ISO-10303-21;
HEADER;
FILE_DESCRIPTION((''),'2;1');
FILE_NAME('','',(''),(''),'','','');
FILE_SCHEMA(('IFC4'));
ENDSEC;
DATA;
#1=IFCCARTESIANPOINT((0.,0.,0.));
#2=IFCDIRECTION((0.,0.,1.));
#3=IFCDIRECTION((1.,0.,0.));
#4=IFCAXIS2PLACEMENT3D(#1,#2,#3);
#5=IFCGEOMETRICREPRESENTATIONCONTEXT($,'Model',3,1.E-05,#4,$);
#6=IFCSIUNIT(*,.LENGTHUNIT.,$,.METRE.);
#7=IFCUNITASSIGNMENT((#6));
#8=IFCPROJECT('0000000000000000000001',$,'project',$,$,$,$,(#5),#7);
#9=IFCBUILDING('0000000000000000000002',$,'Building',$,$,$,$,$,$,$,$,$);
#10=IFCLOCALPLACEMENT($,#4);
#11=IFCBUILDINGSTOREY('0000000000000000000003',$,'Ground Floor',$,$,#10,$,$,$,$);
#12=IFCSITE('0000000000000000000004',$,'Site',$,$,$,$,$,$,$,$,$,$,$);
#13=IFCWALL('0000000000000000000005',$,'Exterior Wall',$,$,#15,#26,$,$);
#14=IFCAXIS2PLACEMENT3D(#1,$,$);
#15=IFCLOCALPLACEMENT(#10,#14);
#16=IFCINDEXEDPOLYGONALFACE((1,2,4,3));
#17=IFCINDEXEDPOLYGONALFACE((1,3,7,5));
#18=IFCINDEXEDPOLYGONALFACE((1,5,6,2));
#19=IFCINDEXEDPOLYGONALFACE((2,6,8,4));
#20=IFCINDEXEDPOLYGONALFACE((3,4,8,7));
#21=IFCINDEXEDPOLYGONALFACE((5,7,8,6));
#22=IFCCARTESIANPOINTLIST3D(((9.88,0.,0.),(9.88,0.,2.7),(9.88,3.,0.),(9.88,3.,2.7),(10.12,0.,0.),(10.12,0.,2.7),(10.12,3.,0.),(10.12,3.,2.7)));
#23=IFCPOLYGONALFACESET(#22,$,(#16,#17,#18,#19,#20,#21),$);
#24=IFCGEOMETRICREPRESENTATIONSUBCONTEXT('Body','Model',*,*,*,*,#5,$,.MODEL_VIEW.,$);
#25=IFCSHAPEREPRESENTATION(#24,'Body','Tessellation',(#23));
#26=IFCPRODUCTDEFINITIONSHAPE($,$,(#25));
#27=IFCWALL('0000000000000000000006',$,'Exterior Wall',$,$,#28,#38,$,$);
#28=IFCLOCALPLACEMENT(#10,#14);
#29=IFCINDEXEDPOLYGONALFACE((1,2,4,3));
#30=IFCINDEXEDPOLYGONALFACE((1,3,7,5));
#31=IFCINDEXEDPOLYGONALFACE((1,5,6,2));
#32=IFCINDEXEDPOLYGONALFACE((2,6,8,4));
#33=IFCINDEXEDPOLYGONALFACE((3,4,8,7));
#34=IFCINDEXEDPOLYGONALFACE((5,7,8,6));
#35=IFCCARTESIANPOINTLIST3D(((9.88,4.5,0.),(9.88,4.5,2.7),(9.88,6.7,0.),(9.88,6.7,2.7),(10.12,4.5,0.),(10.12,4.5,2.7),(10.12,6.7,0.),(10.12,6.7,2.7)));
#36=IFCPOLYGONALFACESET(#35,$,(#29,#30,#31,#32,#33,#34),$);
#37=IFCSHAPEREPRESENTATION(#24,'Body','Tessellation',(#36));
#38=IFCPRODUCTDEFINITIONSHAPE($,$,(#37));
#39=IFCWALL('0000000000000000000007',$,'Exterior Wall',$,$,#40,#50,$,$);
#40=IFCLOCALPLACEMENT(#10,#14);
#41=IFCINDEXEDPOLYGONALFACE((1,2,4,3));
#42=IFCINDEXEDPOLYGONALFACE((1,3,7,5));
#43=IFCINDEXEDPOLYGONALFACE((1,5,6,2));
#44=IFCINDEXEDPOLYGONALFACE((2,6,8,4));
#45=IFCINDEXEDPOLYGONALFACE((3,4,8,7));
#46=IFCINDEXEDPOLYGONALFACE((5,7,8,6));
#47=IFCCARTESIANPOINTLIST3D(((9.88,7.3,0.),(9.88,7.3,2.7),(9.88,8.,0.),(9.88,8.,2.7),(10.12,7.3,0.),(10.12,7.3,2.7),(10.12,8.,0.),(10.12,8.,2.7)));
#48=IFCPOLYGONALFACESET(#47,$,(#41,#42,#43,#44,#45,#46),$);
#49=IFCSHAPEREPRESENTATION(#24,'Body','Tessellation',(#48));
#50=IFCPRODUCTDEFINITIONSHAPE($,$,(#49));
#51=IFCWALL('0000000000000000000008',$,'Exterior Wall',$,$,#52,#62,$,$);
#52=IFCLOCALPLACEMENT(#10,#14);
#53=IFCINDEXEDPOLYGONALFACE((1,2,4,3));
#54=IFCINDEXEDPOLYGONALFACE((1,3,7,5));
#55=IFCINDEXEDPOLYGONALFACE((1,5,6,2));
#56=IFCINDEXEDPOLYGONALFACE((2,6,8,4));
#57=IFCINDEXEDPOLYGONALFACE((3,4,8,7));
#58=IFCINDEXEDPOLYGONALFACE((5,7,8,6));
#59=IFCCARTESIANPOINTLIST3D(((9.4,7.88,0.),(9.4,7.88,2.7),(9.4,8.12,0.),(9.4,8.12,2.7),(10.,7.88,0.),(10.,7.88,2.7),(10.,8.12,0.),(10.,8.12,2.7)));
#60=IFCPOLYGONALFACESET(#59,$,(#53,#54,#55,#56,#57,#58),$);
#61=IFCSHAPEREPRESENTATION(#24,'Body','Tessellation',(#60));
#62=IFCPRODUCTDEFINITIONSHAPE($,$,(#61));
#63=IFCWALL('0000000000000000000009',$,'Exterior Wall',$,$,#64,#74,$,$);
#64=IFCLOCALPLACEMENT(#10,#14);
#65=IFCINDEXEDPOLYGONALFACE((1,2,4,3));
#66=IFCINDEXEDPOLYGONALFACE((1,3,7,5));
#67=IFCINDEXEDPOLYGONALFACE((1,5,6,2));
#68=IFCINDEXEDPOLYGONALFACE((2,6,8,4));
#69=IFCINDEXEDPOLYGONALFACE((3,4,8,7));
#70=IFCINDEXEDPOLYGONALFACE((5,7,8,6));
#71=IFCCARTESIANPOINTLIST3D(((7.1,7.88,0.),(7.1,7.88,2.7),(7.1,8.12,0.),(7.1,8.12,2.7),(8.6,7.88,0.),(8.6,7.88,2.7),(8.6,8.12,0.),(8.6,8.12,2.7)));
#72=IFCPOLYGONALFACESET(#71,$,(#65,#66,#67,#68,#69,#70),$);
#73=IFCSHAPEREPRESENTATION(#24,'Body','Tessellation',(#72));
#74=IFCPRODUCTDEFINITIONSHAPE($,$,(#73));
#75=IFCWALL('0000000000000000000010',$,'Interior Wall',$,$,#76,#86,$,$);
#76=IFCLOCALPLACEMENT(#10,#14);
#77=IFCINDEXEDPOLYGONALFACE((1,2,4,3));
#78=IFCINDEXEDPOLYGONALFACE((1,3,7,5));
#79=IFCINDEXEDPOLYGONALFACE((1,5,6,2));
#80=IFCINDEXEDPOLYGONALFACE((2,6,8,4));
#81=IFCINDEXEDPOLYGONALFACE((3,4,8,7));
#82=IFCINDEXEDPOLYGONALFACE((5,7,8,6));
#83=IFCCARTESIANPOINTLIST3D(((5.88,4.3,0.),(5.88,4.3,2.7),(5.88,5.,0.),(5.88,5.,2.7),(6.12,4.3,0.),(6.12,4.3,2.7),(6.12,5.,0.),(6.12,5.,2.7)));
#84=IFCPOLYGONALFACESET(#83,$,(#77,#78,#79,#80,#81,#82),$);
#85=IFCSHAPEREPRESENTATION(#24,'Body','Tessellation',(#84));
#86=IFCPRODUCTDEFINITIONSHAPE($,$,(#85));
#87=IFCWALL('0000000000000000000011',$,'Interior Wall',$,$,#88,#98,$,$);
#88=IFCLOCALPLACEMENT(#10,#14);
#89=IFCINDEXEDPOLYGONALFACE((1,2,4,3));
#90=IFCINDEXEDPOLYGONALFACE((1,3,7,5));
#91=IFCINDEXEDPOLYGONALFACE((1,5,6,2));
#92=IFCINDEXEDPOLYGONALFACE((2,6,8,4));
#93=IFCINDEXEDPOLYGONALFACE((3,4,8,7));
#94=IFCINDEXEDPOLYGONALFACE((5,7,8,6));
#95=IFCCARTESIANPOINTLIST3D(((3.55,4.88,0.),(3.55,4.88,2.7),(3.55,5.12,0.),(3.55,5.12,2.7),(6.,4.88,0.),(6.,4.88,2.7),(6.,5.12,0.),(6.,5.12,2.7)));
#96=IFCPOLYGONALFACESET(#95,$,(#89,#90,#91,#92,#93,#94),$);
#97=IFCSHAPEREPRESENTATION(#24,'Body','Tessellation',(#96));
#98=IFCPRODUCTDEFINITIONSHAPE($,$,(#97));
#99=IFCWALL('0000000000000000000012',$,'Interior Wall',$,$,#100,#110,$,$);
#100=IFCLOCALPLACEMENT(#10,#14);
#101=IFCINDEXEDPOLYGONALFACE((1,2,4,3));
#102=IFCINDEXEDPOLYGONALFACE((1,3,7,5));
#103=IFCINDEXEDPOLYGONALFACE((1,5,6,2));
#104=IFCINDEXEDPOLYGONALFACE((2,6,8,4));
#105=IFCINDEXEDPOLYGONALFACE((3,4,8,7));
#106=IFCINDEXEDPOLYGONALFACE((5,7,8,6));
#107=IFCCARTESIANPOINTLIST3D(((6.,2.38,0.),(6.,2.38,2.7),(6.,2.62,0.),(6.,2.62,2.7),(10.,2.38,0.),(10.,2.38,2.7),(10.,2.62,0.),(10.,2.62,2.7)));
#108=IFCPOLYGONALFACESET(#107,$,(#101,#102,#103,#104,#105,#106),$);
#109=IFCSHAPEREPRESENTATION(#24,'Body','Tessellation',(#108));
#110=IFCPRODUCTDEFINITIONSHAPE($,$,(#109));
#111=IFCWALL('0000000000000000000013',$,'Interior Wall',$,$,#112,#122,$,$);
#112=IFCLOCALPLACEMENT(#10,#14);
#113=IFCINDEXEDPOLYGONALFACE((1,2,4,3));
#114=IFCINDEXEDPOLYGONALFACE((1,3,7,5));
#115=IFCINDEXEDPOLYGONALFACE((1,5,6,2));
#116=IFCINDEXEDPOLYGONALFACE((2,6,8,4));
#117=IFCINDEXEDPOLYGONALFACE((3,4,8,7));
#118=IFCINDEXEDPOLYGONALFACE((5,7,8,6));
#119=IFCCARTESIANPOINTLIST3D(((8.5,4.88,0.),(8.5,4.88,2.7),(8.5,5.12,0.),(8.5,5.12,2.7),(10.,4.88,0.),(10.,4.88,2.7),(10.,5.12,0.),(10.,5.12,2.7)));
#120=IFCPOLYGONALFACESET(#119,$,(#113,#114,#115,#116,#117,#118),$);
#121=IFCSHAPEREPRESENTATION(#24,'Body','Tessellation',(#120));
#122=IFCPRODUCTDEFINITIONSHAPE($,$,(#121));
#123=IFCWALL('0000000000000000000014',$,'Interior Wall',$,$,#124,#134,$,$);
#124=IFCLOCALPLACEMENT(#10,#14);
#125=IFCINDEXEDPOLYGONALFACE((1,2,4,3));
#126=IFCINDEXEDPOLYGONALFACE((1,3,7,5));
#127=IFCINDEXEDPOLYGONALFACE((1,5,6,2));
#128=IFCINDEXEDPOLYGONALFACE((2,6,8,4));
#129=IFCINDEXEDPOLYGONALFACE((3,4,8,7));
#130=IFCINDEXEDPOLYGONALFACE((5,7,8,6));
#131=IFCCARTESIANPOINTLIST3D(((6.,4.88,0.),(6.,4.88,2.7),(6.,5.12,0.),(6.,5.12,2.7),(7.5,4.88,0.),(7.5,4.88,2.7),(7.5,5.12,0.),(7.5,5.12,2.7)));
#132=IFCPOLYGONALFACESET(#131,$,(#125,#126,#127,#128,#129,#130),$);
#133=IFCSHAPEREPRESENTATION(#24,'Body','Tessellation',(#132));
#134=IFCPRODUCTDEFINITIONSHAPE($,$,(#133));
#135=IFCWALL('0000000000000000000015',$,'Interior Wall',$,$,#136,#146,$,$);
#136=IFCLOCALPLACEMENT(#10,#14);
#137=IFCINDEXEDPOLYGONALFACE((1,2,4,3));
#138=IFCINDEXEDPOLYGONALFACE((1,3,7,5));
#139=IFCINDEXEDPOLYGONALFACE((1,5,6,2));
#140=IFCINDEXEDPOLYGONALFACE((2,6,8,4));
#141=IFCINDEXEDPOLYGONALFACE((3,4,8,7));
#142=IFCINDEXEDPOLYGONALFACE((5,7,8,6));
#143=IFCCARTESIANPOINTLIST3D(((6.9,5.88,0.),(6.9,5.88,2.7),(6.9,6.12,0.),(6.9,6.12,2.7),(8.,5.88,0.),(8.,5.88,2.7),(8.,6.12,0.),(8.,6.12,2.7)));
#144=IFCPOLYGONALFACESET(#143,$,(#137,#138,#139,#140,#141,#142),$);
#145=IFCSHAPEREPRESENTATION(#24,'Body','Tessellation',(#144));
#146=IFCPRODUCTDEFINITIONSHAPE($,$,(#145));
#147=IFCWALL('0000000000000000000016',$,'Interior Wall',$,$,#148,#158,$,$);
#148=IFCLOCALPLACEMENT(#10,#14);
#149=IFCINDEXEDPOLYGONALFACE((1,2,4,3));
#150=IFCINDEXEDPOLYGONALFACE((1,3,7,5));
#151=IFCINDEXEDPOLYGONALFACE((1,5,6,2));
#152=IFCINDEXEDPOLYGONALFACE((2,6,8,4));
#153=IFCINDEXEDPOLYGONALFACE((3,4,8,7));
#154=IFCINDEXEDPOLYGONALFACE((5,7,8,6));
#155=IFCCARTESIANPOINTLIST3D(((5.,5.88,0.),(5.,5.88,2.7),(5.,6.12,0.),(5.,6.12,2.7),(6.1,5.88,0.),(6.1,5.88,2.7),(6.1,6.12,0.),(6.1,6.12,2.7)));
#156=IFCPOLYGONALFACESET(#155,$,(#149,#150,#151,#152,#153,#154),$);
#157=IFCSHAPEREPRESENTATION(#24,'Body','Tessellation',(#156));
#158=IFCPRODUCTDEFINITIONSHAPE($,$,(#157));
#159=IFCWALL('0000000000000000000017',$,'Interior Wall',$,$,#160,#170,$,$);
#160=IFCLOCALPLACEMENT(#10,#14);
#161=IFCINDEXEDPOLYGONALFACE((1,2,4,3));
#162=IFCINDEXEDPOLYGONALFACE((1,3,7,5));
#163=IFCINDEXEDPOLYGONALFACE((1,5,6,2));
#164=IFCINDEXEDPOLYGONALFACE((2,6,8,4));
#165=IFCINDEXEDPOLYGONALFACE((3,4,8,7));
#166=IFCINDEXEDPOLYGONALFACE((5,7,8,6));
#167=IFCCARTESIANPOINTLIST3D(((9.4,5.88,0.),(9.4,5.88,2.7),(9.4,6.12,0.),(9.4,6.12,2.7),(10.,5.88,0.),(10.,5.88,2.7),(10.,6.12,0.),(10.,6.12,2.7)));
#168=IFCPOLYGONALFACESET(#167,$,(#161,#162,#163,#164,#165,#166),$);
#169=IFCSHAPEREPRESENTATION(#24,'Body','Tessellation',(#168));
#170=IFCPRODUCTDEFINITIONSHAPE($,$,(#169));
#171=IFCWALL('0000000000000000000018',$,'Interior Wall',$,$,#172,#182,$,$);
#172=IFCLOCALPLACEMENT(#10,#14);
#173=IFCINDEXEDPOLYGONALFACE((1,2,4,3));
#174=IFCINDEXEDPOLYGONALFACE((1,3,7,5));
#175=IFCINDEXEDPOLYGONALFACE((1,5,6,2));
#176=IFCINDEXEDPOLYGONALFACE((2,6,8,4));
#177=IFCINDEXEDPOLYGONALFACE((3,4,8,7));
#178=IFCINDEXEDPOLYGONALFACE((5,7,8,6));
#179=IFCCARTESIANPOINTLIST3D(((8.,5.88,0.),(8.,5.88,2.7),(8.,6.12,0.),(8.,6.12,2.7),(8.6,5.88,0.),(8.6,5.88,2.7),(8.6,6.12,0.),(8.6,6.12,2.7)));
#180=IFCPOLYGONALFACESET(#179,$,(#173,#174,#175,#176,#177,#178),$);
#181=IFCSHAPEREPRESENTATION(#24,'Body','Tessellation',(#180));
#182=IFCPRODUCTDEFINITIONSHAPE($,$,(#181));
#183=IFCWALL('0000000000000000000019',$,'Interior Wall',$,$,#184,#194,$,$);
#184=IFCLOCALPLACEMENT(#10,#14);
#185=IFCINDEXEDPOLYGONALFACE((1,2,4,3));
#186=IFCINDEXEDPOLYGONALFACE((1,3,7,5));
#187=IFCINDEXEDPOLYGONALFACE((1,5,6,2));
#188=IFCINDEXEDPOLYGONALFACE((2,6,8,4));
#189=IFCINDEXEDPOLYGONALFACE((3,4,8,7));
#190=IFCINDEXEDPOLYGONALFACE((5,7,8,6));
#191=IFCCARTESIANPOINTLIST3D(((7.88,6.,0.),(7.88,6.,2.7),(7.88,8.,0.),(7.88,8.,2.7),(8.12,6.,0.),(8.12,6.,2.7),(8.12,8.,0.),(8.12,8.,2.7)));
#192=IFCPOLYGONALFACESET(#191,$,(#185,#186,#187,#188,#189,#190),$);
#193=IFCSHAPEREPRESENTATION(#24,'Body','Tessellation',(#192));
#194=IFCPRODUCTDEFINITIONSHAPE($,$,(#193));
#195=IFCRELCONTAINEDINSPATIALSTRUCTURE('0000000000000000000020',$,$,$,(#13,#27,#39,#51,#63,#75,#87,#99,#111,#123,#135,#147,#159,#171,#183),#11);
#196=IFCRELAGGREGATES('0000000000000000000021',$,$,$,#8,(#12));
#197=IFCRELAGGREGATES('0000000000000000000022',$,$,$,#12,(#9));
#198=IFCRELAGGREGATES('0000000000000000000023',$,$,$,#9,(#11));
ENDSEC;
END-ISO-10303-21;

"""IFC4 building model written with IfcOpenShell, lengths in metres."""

from ifc_helpers import new_model, si_unit, frame, origin_with_axes, place, context, subcontext, project, spatial, indexed_curve, outline, extrude, element, save


model = new_model("IFC4")

# Units and contexts
model_context = context("Model", 3, precision=1e-05, world=origin_with_axes())
body_context = subcontext(model_context, "Body", "Model", "MODEL_VIEW")
ifc_project = project(units=[si_unit("LENGTHUNIT", "METRE")], contexts=[model_context])

# Site, building, storey
site = spatial("IfcSite", under=ifc_project, Name="Site")
building = spatial("IfcBuilding", under=site, Name="Building")
storey_placement = place(None, origin_with_axes())
storey = spatial("IfcBuildingStorey", under=building, at=storey_placement, Name="Ground Floor")

# Walls
wall_1_placement = place(storey_placement, frame((10.0, 0.0, 0.0), z_axis=(0.0, 0.0, 1.0), x_axis=(0.0, 1.0, 0.0)))
element("IfcWall", 1, at=wall_1_placement, inside=storey, Name="Exterior Wall", context=body_context, shape_type="SweptSolid", body=[
    extrude(outline(indexed_curve([(0.0, 0.0), (0.0, 0.24), (3.0, 0.24), (3.0, 0.0), (0.0, 0.0)], self_intersect=False)), frame((0.0, -0.12, 0.0), z_axis=(0.0, 0.0, 1.0), x_axis=(1.0, 0.0, 0.0)), (0.0, 0.0, 1.0), 2.7),
])
wall_2_placement = place(storey_placement, frame((10.0, 4.5, 0.0), z_axis=(0.0, 0.0, 1.0), x_axis=(0.0, 1.0, 0.0)))
element("IfcWall", 2, at=wall_2_placement, inside=storey, Name="Exterior Wall", context=body_context, shape_type="SweptSolid", body=[
    extrude(outline(indexed_curve([(0.0, 0.0), (0.0, 0.24), (2.2, 0.24), (2.2, 0.0), (0.0, 0.0)], self_intersect=False)), frame((0.0, -0.12, 0.0), z_axis=(0.0, 0.0, 1.0), x_axis=(1.0, 0.0, 0.0)), (0.0, 0.0, 1.0), 2.7),
])
wall_3_placement = place(storey_placement, frame((10.0, 7.3, 0.0), z_axis=(0.0, 0.0, 1.0), x_axis=(0.0, 1.0, 0.0)))
element("IfcWall", 3, at=wall_3_placement, inside=storey, Name="Exterior Wall", context=body_context, shape_type="SweptSolid", body=[
    extrude(outline(indexed_curve([(0.0, 0.0), (0.0, 0.24), (0.7, 0.24), (0.7, 0.0), (0.0, 0.0)], self_intersect=False)), frame((0.0, -0.12, 0.0), z_axis=(0.0, 0.0, 1.0), x_axis=(1.0, 0.0, 0.0)), (0.0, 0.0, 1.0), 2.7),
])
wall_4_placement = place(storey_placement, frame((10.0, 8.0, 0.0), z_axis=(0.0, 0.0, 1.0), x_axis=(-1.0, 0.0, 0.0)))
element("IfcWall", 4, at=wall_4_placement, inside=storey, Name="Exterior Wall", context=body_context, shape_type="SweptSolid", body=[
    extrude(outline(indexed_curve([(0.0, 0.0), (0.0, 0.24), (0.6, 0.24), (0.6, 0.0), (0.0, 0.0)], self_intersect=False)), frame((0.0, -0.12, 0.0), z_axis=(0.0, 0.0, 1.0), x_axis=(1.0, 0.0, 0.0)), (0.0, 0.0, 1.0), 2.7),
])
wall_5_placement = place(storey_placement, frame((8.6, 8.0, 0.0), z_axis=(0.0, 0.0, 1.0), x_axis=(-1.0, 0.0, 0.0)))
element("IfcWall", 5, at=wall_5_placement, inside=storey, Name="Exterior Wall", context=body_context, shape_type="SweptSolid", body=[
    extrude(outline(indexed_curve([(0.0, 0.0), (0.0, 0.24), (1.5, 0.24), (1.5, 0.0), (0.0, 0.0)], self_intersect=False)), frame((0.0, -0.12, 0.0), z_axis=(0.0, 0.0, 1.0), x_axis=(1.0, 0.0, 0.0)), (0.0, 0.0, 1.0), 2.7),
])
wall_6_placement = place(storey_placement, frame((6.0, 4.3, 0.0), z_axis=(0.0, 0.0, 1.0), x_axis=(0.0, 1.0, 0.0)))
element("IfcWall", 6, at=wall_6_placement, inside=storey, Name="Interior Wall", context=body_context, shape_type="SweptSolid", body=[
    extrude(outline(indexed_curve([(0.0, 0.0), (0.0, 0.24), (0.7, 0.24), (0.7, 0.0), (0.0, 0.0)], self_intersect=False)), frame((0.0, -0.12, 0.0), z_axis=(0.0, 0.0, 1.0), x_axis=(1.0, 0.0, 0.0)), (0.0, 0.0, 1.0), 2.7),
])
wall_7_placement = place(storey_placement, frame((6.0, 5.0, 0.0), z_axis=(0.0, 0.0, 1.0), x_axis=(-1.0, 0.0, 0.0)))
element("IfcWall", 7, at=wall_7_placement, inside=storey, Name="Interior Wall", context=body_context, shape_type="SweptSolid", body=[
    extrude(outline(indexed_curve([(0.0, 0.0), (0.0, 0.24), (2.45, 0.24), (2.45, 0.0), (0.0, 0.0)], self_intersect=False)), frame((0.0, -0.12, 0.0), z_axis=(0.0, 0.0, 1.0), x_axis=(1.0, 0.0, 0.0)), (0.0, 0.0, 1.0), 2.7),
])
wall_8_placement = place(storey_placement, frame((10.0, 2.5, 0.0), z_axis=(0.0, 0.0, 1.0), x_axis=(-1.0, 0.0, 0.0)))
element("IfcWall", 8, at=wall_8_placement, inside=storey, Name="Interior Wall", context=body_context, shape_type="SweptSolid", body=[
    extrude(outline(indexed_curve([(0.0, 0.0), (0.0, 0.24), (4.0, 0.24), (4.0, 0.0), (0.0, 0.0)], self_intersect=False)), frame((0.0, -0.12, 0.0), z_axis=(0.0, 0.0, 1.0), x_axis=(1.0, 0.0, 0.0)), (0.0, 0.0, 1.0), 2.7),
])
for number, where, z_axis, x_axis, name in (
    (9, (10.0, 5.0, 0.0), (0.0, 0.0, 1.0), (-1.0, 0.0, 0.0), "Interior Wall"),
    (10, (7.5, 5.0, 0.0), (0.0, 0.0, 1.0), (-1.0, 0.0, 0.0), "Interior Wall"),
):
    element("IfcWall", number, at=place(storey_placement, frame(where, z_axis=z_axis, x_axis=x_axis)), inside=storey, Name=name, context=body_context, shape_type="SweptSolid", body=[
        extrude(outline(indexed_curve([(0.0, 0.0), (0.0, 0.24), (1.5, 0.24), (1.5, 0.0), (0.0, 0.0)], self_intersect=False)), frame((0.0, -0.12, 0.0), z_axis=(0.0, 0.0, 1.0), x_axis=(1.0, 0.0, 0.0)), (0.0, 0.0, 1.0), 2.7),
    ])
for number, where, z_axis, x_axis, name in (
    (11, (8.0, 6.0, 0.0), (0.0, 0.0, 1.0), (-1.0, 0.0, 0.0), "Interior Wall"),
    (12, (6.1, 6.0, 0.0), (0.0, 0.0, 1.0), (-1.0, 0.0, 0.0), "Interior Wall"),
):
    element("IfcWall", number, at=place(storey_placement, frame(where, z_axis=z_axis, x_axis=x_axis)), inside=storey, Name=name, context=body_context, shape_type="SweptSolid", body=[
        extrude(outline(indexed_curve([(0.0, 0.0), (0.0, 0.24), (1.1, 0.24), (1.1, 0.0), (0.0, 0.0)], self_intersect=False)), frame((0.0, -0.12, 0.0), z_axis=(0.0, 0.0, 1.0), x_axis=(1.0, 0.0, 0.0)), (0.0, 0.0, 1.0), 2.7),
    ])
for number, where, z_axis, x_axis, name in (
    (13, (10.0, 6.0, 0.0), (0.0, 0.0, 1.0), (-1.0, 0.0, 0.0), "Interior Wall"),
    (14, (8.6, 6.0, 0.0), (0.0, 0.0, 1.0), (-1.0, 0.0, 0.0), "Interior Wall"),
):
    element("IfcWall", number, at=place(storey_placement, frame(where, z_axis=z_axis, x_axis=x_axis)), inside=storey, Name=name, context=body_context, shape_type="SweptSolid", body=[
        extrude(outline(indexed_curve([(0.0, 0.0), (0.0, 0.24), (0.6, 0.24), (0.6, 0.0), (0.0, 0.0)], self_intersect=False)), frame((0.0, -0.12, 0.0), z_axis=(0.0, 0.0, 1.0), x_axis=(1.0, 0.0, 0.0)), (0.0, 0.0, 1.0), 2.7),
    ])
wall_9_placement = place(storey_placement, frame((8.0, 6.0, 0.0), z_axis=(0.0, 0.0, 1.0), x_axis=(0.0, 1.0, 0.0)))
element("IfcWall", 15, at=wall_9_placement, inside=storey, Name="Interior Wall", context=body_context, shape_type="SweptSolid", body=[
    extrude(outline(indexed_curve([(0.0, 0.0), (0.0, 0.24), (2.0, 0.24), (2.0, 0.0), (0.0, 0.0)], self_intersect=False)), frame((0.0, -0.12, 0.0), z_axis=(0.0, 0.0, 1.0), x_axis=(1.0, 0.0, 0.0)), (0.0, 0.0, 1.0), 2.7),
])

save(model, "model.ifc")
